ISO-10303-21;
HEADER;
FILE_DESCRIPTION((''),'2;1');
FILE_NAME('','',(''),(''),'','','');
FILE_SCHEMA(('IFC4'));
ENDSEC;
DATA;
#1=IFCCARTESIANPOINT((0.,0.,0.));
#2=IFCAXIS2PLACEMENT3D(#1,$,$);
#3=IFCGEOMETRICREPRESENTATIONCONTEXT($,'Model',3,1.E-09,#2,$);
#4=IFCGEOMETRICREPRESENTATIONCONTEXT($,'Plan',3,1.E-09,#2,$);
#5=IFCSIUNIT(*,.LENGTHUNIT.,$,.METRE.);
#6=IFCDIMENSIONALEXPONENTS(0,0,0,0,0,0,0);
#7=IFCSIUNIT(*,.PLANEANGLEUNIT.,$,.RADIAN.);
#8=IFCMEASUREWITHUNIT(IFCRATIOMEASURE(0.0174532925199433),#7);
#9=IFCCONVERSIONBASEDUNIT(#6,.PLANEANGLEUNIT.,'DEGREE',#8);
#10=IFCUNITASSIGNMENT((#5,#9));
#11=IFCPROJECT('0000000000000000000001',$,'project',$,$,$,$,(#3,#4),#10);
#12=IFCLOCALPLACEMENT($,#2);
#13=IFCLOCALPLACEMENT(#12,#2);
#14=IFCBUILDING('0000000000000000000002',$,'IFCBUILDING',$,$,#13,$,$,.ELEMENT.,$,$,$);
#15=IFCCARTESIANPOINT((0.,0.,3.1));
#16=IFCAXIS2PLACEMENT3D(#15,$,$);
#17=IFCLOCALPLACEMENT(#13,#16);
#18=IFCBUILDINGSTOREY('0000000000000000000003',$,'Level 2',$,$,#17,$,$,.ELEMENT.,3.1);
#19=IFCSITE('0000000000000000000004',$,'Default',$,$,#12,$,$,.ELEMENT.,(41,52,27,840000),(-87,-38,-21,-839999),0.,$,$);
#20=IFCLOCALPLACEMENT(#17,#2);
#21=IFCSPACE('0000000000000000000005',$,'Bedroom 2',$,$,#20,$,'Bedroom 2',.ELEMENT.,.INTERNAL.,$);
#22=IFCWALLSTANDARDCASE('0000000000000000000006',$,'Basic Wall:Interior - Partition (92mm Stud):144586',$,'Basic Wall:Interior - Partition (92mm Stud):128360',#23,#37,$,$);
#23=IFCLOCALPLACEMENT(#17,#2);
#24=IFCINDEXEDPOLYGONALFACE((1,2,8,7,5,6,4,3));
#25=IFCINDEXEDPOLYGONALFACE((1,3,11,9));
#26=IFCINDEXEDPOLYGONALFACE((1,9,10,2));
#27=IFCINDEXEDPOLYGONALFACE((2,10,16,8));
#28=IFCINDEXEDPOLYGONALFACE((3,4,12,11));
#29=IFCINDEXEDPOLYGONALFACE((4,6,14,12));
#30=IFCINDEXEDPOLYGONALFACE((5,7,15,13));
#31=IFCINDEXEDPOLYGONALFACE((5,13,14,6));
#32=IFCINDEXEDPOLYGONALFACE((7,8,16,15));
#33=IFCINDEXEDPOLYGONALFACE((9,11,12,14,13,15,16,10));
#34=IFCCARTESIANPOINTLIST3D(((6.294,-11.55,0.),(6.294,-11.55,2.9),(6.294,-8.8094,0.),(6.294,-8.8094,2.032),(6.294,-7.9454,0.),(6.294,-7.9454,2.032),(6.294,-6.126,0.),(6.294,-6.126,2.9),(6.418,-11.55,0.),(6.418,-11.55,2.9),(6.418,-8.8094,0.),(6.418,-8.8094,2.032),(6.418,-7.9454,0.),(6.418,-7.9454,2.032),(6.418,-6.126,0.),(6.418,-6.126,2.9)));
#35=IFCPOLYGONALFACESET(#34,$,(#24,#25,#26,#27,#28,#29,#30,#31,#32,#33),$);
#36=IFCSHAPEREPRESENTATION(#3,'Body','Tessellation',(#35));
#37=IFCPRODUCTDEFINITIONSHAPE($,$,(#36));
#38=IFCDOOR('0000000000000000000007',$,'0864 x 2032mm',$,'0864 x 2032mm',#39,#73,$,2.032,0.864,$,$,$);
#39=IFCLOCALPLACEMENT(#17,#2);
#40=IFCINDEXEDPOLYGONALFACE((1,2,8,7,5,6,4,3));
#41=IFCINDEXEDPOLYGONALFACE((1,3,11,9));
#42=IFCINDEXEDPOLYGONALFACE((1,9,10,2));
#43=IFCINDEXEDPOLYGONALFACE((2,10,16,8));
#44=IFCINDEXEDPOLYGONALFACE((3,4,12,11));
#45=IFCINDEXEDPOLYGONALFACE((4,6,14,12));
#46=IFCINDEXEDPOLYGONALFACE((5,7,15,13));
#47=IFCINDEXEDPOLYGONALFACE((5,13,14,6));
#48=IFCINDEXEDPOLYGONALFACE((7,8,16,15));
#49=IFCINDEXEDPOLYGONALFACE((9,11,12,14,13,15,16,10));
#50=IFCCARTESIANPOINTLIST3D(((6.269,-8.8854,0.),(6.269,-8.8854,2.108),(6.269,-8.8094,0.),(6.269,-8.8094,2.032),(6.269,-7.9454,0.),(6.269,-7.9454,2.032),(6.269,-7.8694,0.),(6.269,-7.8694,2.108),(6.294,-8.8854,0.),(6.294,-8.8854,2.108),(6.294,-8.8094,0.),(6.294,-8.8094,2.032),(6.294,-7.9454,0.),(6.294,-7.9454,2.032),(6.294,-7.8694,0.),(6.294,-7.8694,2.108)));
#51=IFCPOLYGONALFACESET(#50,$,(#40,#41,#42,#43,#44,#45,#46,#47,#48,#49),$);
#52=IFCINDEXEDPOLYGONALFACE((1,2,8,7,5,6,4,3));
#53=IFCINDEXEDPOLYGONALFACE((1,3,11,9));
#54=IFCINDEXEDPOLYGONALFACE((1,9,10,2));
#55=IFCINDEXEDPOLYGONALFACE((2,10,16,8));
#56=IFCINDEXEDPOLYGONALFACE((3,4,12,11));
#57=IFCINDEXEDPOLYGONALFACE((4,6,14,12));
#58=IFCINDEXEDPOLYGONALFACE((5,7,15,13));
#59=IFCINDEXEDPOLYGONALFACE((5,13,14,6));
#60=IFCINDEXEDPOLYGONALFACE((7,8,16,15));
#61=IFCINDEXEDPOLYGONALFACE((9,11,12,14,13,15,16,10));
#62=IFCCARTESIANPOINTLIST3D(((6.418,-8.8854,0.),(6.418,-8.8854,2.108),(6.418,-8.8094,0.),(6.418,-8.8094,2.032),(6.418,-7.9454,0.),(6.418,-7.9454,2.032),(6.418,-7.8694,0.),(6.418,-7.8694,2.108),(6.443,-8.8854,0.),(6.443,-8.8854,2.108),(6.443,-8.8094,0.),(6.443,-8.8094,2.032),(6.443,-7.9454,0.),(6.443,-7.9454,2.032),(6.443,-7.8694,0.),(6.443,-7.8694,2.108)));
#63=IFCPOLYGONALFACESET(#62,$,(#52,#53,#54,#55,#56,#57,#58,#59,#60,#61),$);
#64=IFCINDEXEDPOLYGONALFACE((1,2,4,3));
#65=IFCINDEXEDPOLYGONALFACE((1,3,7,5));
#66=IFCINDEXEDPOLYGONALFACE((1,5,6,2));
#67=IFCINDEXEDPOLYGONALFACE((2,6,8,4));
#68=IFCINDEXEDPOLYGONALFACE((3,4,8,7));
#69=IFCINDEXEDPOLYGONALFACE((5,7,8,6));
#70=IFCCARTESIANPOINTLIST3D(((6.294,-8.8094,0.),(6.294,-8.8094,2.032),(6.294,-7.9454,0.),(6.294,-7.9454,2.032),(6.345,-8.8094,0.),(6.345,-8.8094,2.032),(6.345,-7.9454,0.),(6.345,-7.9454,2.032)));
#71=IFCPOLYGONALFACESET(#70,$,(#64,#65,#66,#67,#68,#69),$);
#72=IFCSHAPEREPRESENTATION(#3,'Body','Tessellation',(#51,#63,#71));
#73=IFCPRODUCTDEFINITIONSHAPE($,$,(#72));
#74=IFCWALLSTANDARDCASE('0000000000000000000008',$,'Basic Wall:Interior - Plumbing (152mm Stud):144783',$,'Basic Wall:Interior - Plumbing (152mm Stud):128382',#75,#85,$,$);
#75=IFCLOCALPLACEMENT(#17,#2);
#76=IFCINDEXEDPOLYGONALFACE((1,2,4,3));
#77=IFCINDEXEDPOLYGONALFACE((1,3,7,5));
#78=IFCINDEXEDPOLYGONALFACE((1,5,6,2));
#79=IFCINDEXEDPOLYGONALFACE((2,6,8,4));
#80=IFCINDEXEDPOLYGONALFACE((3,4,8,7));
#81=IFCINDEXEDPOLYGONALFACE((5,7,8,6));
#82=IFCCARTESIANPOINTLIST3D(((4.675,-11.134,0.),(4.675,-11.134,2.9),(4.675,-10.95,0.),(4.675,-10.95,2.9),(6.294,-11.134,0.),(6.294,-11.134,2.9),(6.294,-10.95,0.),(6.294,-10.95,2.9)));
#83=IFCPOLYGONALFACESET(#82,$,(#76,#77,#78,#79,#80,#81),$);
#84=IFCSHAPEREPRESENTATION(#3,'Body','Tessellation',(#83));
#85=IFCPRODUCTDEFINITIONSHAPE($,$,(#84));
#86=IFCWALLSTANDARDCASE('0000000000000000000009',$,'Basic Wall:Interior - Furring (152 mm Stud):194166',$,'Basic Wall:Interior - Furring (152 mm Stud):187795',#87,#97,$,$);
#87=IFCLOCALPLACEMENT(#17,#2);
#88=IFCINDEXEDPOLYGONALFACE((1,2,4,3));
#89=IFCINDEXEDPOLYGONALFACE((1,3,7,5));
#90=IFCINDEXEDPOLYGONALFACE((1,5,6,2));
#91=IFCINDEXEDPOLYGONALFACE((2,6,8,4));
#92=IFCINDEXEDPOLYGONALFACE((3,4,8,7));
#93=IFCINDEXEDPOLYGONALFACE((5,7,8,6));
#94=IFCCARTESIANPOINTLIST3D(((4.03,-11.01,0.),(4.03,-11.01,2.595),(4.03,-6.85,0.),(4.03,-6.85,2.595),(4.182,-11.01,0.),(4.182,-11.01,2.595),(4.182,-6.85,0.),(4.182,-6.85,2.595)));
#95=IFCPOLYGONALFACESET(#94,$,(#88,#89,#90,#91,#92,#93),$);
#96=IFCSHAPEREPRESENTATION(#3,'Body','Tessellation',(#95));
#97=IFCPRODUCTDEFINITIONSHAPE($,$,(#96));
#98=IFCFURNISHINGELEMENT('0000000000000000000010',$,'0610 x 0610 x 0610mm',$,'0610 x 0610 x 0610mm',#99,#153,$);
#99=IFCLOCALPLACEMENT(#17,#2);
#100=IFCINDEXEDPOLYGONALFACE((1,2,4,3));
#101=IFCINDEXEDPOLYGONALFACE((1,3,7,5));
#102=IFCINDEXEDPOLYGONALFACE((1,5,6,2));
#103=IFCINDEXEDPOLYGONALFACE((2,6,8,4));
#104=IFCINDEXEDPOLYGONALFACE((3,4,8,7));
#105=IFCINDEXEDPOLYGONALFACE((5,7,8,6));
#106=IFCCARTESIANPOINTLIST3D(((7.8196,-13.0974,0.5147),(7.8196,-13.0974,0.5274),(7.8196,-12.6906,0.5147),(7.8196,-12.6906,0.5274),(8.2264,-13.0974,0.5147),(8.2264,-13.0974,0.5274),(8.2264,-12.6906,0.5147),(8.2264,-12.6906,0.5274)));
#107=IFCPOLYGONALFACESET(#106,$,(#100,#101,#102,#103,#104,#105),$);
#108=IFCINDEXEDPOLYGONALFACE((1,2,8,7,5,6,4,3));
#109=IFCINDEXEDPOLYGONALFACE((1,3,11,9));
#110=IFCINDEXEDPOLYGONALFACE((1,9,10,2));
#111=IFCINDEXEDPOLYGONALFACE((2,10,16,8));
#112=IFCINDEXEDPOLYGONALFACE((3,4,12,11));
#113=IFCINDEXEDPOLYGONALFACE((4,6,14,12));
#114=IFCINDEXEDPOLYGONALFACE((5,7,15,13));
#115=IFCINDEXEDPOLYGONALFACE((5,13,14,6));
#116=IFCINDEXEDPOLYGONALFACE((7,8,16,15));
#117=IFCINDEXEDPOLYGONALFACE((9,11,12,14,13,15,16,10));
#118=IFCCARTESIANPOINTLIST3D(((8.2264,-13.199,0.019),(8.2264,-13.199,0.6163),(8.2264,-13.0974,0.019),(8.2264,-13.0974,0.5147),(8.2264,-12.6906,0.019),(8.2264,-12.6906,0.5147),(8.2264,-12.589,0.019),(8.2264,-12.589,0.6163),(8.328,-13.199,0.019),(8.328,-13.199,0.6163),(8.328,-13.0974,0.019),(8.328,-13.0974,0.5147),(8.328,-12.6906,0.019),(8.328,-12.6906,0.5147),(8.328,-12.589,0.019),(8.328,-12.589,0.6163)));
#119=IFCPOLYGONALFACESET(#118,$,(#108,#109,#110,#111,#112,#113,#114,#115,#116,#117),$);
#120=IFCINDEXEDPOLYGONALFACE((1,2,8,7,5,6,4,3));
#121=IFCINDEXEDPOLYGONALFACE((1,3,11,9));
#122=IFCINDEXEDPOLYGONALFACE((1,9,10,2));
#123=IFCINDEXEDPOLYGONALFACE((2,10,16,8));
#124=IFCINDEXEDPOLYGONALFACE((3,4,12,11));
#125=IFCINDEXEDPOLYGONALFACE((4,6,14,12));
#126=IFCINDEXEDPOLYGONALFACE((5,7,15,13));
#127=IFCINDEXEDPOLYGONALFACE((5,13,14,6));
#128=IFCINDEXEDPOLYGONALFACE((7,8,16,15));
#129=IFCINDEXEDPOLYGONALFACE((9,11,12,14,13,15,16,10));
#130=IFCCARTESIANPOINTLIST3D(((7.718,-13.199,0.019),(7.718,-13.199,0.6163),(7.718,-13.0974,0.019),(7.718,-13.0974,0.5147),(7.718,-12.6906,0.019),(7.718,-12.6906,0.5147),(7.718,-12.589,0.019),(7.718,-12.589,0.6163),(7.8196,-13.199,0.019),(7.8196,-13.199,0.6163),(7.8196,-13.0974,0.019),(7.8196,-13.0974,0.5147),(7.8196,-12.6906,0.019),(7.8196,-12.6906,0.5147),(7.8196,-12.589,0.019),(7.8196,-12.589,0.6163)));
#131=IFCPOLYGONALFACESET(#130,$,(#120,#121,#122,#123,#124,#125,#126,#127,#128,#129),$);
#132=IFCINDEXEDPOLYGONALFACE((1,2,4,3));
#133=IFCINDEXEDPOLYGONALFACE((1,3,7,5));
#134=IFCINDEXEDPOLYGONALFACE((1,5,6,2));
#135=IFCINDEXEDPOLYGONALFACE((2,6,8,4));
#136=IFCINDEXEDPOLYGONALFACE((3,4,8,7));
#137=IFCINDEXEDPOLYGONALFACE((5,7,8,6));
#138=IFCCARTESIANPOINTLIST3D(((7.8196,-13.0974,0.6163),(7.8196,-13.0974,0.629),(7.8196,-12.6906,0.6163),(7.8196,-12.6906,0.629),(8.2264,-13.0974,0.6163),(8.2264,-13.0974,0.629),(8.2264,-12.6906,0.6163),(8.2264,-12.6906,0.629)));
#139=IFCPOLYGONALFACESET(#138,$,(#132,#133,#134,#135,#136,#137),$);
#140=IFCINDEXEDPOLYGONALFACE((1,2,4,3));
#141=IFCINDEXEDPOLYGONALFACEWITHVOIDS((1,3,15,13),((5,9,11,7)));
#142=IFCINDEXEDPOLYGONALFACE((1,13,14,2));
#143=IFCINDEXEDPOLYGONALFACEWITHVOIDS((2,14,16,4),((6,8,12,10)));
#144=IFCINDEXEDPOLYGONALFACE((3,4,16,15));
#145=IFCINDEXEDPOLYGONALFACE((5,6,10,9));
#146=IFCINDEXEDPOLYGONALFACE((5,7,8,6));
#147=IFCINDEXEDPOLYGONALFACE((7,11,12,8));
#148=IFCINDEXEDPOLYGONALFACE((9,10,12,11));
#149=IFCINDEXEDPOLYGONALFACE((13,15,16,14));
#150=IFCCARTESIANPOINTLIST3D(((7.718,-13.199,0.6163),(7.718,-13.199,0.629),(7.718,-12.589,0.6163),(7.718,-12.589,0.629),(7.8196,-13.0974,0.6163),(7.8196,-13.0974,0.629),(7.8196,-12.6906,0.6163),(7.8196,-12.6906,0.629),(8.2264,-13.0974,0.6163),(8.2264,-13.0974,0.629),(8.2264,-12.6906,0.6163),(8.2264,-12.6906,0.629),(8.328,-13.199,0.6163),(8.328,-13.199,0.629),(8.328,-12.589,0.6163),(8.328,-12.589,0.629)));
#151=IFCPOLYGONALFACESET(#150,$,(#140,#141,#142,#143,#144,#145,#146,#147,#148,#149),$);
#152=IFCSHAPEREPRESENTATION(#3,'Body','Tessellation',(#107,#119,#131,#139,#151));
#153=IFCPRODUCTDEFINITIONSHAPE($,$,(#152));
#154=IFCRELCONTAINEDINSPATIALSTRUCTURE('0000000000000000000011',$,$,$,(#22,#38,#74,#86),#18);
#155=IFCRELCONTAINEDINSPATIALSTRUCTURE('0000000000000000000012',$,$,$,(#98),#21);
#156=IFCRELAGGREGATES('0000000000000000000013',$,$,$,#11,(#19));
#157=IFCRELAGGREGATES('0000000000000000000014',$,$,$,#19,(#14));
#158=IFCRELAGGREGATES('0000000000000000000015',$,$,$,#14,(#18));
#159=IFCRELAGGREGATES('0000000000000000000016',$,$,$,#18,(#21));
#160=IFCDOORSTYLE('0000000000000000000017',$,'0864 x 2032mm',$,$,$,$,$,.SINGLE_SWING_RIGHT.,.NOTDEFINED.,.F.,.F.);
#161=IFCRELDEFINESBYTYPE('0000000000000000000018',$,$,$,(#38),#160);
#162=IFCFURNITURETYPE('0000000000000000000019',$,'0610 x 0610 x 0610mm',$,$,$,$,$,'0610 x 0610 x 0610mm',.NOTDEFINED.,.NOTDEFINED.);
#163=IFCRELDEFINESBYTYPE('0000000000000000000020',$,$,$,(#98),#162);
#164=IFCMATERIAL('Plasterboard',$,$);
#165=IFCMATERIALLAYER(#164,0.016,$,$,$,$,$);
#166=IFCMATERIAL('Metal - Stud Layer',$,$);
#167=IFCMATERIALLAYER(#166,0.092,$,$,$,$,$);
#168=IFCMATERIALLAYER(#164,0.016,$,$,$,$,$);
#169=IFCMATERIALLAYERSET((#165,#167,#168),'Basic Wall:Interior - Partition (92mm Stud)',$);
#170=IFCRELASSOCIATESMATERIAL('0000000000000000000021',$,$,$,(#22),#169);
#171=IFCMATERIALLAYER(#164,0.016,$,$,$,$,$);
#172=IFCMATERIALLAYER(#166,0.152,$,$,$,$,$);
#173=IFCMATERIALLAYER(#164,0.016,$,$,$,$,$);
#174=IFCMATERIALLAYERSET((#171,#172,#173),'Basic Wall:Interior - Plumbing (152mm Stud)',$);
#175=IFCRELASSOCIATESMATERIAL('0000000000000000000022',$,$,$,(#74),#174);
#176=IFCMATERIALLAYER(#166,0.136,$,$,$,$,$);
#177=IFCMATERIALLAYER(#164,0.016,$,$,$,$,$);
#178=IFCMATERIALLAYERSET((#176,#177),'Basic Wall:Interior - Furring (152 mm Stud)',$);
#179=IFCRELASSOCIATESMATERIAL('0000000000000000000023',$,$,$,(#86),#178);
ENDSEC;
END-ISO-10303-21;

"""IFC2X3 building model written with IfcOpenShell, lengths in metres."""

from ifc_helpers import new_model, entity, si_unit, converted_unit, frame, frame_2d, origin, origin_2d_with_axis, place, context, project, spatial, polyline, rectangle, outline, extrude, source, transform, mapped, material, layer, layer_set, layer_usage, type_object, type_shapes, element, fill, save


model = new_model("IFC2X3")

# Units and contexts
model_context = context("Model", 3, precision=1e-09, world=origin())
plan_context = context("Plan", 3, precision=1e-09, world=origin())
ifc_project = project(units=[si_unit("LENGTHUNIT", "METRE"), converted_unit("PLANEANGLEUNIT", "DEGREE", entity("IfcRatioMeasure", 0.0174532925199433), si_unit("PLANEANGLEUNIT", "RADIAN"), dimensions=[0, 0, 0, 0, 0, 0, 0])], contexts=[model_context, plan_context])

# Site, building, storey
site_placement = place(None, origin())
site = spatial("IfcSite", under=ifc_project, at=site_placement, Name="Default", CompositionType="ELEMENT", RefLatitude=(41, 52, 27, 840000), RefLongitude=(-87, -38, -21, -839999), RefElevation=0.0)
building_placement = place(site_placement, origin())
building = spatial("IfcBuilding", under=site, at=building_placement, Name="IFCBUILDING", CompositionType="ELEMENT")
storey_placement = place(building_placement, frame((0.0, 0.0, 3.1)))
storey = spatial("IfcBuildingStorey", under=building, at=storey_placement, Name="Level 2", CompositionType="ELEMENT", Elevation=3.1)

# Shared definitions
ifc_material_1 = material(Name="Metal - Stud Layer")
ifc_material_2 = material(Name="Plasterboard")

# Shared definitions
ifc_layer_1 = layer(ifc_material_2, 0.016)
ifc_layer_2 = layer(ifc_material_1, 0.092)
ifc_layer_3 = layer(ifc_material_2, 0.016)
ifc_layer_set_1 = layer_set([ifc_layer_1, ifc_layer_2, ifc_layer_3], Name="Basic Wall:Interior - Partition (92mm Stud)")

# Wall, opening, door
ifc_layer_usage_1 = layer_usage(ifc_layer_set_1, "AXIS2", "NEGATIVE", 0.062)
wall_1_placement = place(storey_placement, frame((6.356, -11.55, 0.0), z_axis=(0.0, 0.0, 1.0), x_axis=(0.0, 1.0, 0.0)))
wall_1 = element("IfcWallStandardCase", 1, at=wall_1_placement, inside=storey, material=ifc_layer_usage_1, Name="Basic Wall:Interior - Partition (92mm Stud):144586", ObjectType="Basic Wall:Interior - Partition (92mm Stud):128360", context=model_context, shape_type="SweptSolid", body=[
    extrude(rectangle(XDim=5.424, YDim=0.124, at=frame_2d((2.712, 0.0), x_axis=(-1.0, 0.0))), origin(), (0.0, 0.0, 1.0), 2.9),
])
opening_1_placement = place(wall_1_placement, frame((2.7406, -0.062, 0.0)))
opening_1 = element("IfcOpeningElement", 2, at=opening_1_placement, cuts=wall_1, ObjectType="Opening", context=model_context, shape_type="SweptSolid", body=[
    extrude(rectangle(XDim=0.864, YDim=2.032, at=frame_2d((1.016, 0.432), x_axis=(0.0, 1.0))), frame((0.0, 0.0, 0.0), z_axis=(0.0, 1.0, 0.0), x_axis=(0.0, 0.0, 1.0)), (0.0, 0.0, 1.0), 0.124),
])
door_style = type_object("IfcDoorStyle", Name="0864 x 2032mm", ConstructionType="NOTDEFINED", OperationType="SINGLE_SWING_RIGHT", ParameterTakesPrecedence=False, Sizeable=False)
shared_shape_1 = source(origin(), model_context, "Body", "SweptSolid", [
    extrude(outline(polyline([(-0.508, -1.073), (0.508, -1.073), (0.508, 1.035), (0.432, 1.035), (0.432, -0.997), (-0.432, -0.997), (-0.432, 1.035), (-0.508, 1.035), (-0.508, -1.073)])), frame((0.432, 0.124, 1.035), z_axis=(0.0, 1.0, 0.0), x_axis=(1.0, 0.0, 0.0)), (0.0, 0.0, 1.0), 0.025),
    extrude(outline(polyline([(-1.073, -0.508), (1.035, -0.508), (1.035, -0.432), (-0.997, -0.432), (-0.997, 0.432), (1.035, 0.432), (1.035, 0.508), (-1.073, 0.508), (-1.073, -0.508)])), frame((0.432, -0.025, 1.035), z_axis=(0.0, 1.0, 0.0), x_axis=(0.0, 0.0, -1.0)), (0.0, 0.0, 1.0), 0.025),
    extrude(rectangle(XDim=0.051, YDim=0.864, at=origin_2d_with_axis()), frame((0.432, 0.0985, 0.0), z_axis=(0.0, 0.0, 1.0), x_axis=(0.0, 1.0, 0.0)), (0.0, 0.0, 1.0), 2.032),
])
type_shapes(door_style, [shared_shape_1])
door_placement = place(opening_1_placement, origin())
door = element("IfcDoor", 3, at=door_placement, inside=storey, type_object=door_style, Name="0864 x 2032mm", ObjectType="0864 x 2032mm", OverallHeight=2.032, OverallWidth=0.864, context=model_context, shape_type="MappedRepresentation", body=[
    mapped(shared_shape_1, transform((0.0, 0.0, 0.0), scale=1.0)),
])
fill(opening_1, door)

# Walls
ifc_layer_4 = layer(ifc_material_2, 0.016)
ifc_layer_5 = layer(ifc_material_1, 0.152)
ifc_layer_6 = layer(ifc_material_2, 0.016)
ifc_layer_set_2 = layer_set([ifc_layer_4, ifc_layer_5, ifc_layer_6], Name="Basic Wall:Interior - Plumbing (152mm Stud)")
ifc_layer_usage_2 = layer_usage(ifc_layer_set_2, "AXIS2", "NEGATIVE", 0.092)
wall_2_placement = place(storey_placement, frame((6.294, -11.042, 0.0), z_axis=(0.0, 0.0, 1.0), x_axis=(-1.0, 0.0, 0.0)))
element("IfcWallStandardCase", 4, at=wall_2_placement, inside=storey, material=ifc_layer_usage_2, Name="Basic Wall:Interior - Plumbing (152mm Stud):144783", ObjectType="Basic Wall:Interior - Plumbing (152mm Stud):128382", context=model_context, shape_type="SweptSolid", body=[
    extrude(rectangle(XDim=1.619, YDim=0.184, at=frame_2d((0.8095, 0.0), x_axis=(-1.0, 0.0))), origin(), (0.0, 0.0, 1.0), 2.9),
])
ifc_layer_7 = layer(ifc_material_1, 0.136)
ifc_layer_8 = layer(ifc_material_2, 0.016)
ifc_layer_set_3 = layer_set([ifc_layer_7, ifc_layer_8], Name="Basic Wall:Interior - Furring (152 mm Stud)")
ifc_layer_usage_3 = layer_usage(ifc_layer_set_3, "AXIS2", "POSITIVE", -0.076)
wall_3_placement = place(storey_placement, frame((4.106, -11.01, 0.0), z_axis=(0.0, 0.0, 1.0), x_axis=(0.0, 1.0, 0.0)))
element("IfcWallStandardCase", 5, at=wall_3_placement, inside=storey, material=ifc_layer_usage_3, Name="Basic Wall:Interior - Furring (152 mm Stud):194166", ObjectType="Basic Wall:Interior - Furring (152 mm Stud):187795", context=model_context, shape_type="SweptSolid", body=[
    extrude(rectangle(XDim=4.16, YDim=0.152, at=frame_2d((2.08, 0.0), x_axis=(-1.0, 0.0))), origin(), (0.0, 0.0, 1.0), 2.595),
])

# Shared definitions
space_placement = place(storey_placement, origin())
space = spatial("IfcSpace", under=storey, at=space_placement, Name="Bedroom 2", LongName="Bedroom 2", CompositionType="ELEMENT", InteriorOrExteriorSpace="INTERNAL")

# Furnishing element
furniture_type = type_object("IfcFurnitureType", Name="0610 x 0610 x 0610mm", ElementType="0610 x 0610 x 0610mm", AssemblyPlace="NOTDEFINED")
shared_shape_2 = source(origin(), model_context, "Body", "SweptSolid", [
    extrude(rectangle(XDim=0.4068, YDim=0.4068, at=origin_2d_with_axis()), frame((0.0183, 0.0952, 0.4957), z_axis=(0.0, 0.0, 1.0), x_axis=(-1.0, 0.0, 0.0)), (0.0, 0.0, 1.0), 0.0127),
    extrude(outline(polyline([(-0.2732, -0.305), (0.324, -0.305), (0.324, 0.305), (-0.2732, 0.305), (-0.2732, 0.2034), (0.2225, 0.2034), (0.2225, -0.2034), (-0.2732, -0.2034), (-0.2732, -0.305)])), frame((0.2217, 0.0952, 0.2732), z_axis=(1.0, 0.0, 0.0), x_axis=(0.0, 0.0, 1.0)), (0.0, 0.0, 1.0), 0.1016),
    extrude(outline(polyline([(-0.305, -0.3241), (0.305, -0.3241), (0.305, 0.2733), (0.2034, 0.2733), (0.2034, -0.2224), (-0.2034, -0.2224), (-0.2034, 0.2733), (-0.305, 0.2733), (-0.305, -0.3241)])), frame((-0.2867, 0.0952, 0.2733), z_axis=(1.0, 0.0, 0.0), x_axis=(0.0, -1.0, 0.0)), (0.0, 0.0, 1.0), 0.1016),
    extrude(rectangle(XDim=0.4068, YDim=0.4068, at=origin_2d_with_axis()), frame((0.0183, 0.0952, 0.5973), z_axis=(0.0, 0.0, 1.0), x_axis=(-1.0, 0.0, 0.0)), (0.0, 0.0, 1.0), 0.0127),
    extrude(outline(polyline([(-0.305, -0.305), (0.305, -0.305), (0.305, 0.305), (-0.305, 0.305), (-0.305, -0.305)]), holes=[polyline([(-0.2034, -0.2034), (-0.2034, 0.2034), (0.2034, 0.2034), (0.2034, -0.2034), (-0.2034, -0.2034)])]), frame((0.0183, 0.0952, 0.5973), z_axis=(0.0, 0.0, 1.0), x_axis=(-1.0, 0.0, 0.0)), (0.0, 0.0, 1.0), 0.0127),
])
type_shapes(furniture_type, [shared_shape_2])
furnishing_placement = place(space_placement, frame((8.0047, -12.9892, 0.019)))
element("IfcFurnishingElement", 6, at=furnishing_placement, inside=space, type_object=furniture_type, Name="0610 x 0610 x 0610mm", ObjectType="0610 x 0610 x 0610mm", context=model_context, shape_type="MappedRepresentation", body=[
    mapped(shared_shape_2, transform((0.0, 0.0, 0.0), scale=1.0)),
])

save(model, "model.ifc")
